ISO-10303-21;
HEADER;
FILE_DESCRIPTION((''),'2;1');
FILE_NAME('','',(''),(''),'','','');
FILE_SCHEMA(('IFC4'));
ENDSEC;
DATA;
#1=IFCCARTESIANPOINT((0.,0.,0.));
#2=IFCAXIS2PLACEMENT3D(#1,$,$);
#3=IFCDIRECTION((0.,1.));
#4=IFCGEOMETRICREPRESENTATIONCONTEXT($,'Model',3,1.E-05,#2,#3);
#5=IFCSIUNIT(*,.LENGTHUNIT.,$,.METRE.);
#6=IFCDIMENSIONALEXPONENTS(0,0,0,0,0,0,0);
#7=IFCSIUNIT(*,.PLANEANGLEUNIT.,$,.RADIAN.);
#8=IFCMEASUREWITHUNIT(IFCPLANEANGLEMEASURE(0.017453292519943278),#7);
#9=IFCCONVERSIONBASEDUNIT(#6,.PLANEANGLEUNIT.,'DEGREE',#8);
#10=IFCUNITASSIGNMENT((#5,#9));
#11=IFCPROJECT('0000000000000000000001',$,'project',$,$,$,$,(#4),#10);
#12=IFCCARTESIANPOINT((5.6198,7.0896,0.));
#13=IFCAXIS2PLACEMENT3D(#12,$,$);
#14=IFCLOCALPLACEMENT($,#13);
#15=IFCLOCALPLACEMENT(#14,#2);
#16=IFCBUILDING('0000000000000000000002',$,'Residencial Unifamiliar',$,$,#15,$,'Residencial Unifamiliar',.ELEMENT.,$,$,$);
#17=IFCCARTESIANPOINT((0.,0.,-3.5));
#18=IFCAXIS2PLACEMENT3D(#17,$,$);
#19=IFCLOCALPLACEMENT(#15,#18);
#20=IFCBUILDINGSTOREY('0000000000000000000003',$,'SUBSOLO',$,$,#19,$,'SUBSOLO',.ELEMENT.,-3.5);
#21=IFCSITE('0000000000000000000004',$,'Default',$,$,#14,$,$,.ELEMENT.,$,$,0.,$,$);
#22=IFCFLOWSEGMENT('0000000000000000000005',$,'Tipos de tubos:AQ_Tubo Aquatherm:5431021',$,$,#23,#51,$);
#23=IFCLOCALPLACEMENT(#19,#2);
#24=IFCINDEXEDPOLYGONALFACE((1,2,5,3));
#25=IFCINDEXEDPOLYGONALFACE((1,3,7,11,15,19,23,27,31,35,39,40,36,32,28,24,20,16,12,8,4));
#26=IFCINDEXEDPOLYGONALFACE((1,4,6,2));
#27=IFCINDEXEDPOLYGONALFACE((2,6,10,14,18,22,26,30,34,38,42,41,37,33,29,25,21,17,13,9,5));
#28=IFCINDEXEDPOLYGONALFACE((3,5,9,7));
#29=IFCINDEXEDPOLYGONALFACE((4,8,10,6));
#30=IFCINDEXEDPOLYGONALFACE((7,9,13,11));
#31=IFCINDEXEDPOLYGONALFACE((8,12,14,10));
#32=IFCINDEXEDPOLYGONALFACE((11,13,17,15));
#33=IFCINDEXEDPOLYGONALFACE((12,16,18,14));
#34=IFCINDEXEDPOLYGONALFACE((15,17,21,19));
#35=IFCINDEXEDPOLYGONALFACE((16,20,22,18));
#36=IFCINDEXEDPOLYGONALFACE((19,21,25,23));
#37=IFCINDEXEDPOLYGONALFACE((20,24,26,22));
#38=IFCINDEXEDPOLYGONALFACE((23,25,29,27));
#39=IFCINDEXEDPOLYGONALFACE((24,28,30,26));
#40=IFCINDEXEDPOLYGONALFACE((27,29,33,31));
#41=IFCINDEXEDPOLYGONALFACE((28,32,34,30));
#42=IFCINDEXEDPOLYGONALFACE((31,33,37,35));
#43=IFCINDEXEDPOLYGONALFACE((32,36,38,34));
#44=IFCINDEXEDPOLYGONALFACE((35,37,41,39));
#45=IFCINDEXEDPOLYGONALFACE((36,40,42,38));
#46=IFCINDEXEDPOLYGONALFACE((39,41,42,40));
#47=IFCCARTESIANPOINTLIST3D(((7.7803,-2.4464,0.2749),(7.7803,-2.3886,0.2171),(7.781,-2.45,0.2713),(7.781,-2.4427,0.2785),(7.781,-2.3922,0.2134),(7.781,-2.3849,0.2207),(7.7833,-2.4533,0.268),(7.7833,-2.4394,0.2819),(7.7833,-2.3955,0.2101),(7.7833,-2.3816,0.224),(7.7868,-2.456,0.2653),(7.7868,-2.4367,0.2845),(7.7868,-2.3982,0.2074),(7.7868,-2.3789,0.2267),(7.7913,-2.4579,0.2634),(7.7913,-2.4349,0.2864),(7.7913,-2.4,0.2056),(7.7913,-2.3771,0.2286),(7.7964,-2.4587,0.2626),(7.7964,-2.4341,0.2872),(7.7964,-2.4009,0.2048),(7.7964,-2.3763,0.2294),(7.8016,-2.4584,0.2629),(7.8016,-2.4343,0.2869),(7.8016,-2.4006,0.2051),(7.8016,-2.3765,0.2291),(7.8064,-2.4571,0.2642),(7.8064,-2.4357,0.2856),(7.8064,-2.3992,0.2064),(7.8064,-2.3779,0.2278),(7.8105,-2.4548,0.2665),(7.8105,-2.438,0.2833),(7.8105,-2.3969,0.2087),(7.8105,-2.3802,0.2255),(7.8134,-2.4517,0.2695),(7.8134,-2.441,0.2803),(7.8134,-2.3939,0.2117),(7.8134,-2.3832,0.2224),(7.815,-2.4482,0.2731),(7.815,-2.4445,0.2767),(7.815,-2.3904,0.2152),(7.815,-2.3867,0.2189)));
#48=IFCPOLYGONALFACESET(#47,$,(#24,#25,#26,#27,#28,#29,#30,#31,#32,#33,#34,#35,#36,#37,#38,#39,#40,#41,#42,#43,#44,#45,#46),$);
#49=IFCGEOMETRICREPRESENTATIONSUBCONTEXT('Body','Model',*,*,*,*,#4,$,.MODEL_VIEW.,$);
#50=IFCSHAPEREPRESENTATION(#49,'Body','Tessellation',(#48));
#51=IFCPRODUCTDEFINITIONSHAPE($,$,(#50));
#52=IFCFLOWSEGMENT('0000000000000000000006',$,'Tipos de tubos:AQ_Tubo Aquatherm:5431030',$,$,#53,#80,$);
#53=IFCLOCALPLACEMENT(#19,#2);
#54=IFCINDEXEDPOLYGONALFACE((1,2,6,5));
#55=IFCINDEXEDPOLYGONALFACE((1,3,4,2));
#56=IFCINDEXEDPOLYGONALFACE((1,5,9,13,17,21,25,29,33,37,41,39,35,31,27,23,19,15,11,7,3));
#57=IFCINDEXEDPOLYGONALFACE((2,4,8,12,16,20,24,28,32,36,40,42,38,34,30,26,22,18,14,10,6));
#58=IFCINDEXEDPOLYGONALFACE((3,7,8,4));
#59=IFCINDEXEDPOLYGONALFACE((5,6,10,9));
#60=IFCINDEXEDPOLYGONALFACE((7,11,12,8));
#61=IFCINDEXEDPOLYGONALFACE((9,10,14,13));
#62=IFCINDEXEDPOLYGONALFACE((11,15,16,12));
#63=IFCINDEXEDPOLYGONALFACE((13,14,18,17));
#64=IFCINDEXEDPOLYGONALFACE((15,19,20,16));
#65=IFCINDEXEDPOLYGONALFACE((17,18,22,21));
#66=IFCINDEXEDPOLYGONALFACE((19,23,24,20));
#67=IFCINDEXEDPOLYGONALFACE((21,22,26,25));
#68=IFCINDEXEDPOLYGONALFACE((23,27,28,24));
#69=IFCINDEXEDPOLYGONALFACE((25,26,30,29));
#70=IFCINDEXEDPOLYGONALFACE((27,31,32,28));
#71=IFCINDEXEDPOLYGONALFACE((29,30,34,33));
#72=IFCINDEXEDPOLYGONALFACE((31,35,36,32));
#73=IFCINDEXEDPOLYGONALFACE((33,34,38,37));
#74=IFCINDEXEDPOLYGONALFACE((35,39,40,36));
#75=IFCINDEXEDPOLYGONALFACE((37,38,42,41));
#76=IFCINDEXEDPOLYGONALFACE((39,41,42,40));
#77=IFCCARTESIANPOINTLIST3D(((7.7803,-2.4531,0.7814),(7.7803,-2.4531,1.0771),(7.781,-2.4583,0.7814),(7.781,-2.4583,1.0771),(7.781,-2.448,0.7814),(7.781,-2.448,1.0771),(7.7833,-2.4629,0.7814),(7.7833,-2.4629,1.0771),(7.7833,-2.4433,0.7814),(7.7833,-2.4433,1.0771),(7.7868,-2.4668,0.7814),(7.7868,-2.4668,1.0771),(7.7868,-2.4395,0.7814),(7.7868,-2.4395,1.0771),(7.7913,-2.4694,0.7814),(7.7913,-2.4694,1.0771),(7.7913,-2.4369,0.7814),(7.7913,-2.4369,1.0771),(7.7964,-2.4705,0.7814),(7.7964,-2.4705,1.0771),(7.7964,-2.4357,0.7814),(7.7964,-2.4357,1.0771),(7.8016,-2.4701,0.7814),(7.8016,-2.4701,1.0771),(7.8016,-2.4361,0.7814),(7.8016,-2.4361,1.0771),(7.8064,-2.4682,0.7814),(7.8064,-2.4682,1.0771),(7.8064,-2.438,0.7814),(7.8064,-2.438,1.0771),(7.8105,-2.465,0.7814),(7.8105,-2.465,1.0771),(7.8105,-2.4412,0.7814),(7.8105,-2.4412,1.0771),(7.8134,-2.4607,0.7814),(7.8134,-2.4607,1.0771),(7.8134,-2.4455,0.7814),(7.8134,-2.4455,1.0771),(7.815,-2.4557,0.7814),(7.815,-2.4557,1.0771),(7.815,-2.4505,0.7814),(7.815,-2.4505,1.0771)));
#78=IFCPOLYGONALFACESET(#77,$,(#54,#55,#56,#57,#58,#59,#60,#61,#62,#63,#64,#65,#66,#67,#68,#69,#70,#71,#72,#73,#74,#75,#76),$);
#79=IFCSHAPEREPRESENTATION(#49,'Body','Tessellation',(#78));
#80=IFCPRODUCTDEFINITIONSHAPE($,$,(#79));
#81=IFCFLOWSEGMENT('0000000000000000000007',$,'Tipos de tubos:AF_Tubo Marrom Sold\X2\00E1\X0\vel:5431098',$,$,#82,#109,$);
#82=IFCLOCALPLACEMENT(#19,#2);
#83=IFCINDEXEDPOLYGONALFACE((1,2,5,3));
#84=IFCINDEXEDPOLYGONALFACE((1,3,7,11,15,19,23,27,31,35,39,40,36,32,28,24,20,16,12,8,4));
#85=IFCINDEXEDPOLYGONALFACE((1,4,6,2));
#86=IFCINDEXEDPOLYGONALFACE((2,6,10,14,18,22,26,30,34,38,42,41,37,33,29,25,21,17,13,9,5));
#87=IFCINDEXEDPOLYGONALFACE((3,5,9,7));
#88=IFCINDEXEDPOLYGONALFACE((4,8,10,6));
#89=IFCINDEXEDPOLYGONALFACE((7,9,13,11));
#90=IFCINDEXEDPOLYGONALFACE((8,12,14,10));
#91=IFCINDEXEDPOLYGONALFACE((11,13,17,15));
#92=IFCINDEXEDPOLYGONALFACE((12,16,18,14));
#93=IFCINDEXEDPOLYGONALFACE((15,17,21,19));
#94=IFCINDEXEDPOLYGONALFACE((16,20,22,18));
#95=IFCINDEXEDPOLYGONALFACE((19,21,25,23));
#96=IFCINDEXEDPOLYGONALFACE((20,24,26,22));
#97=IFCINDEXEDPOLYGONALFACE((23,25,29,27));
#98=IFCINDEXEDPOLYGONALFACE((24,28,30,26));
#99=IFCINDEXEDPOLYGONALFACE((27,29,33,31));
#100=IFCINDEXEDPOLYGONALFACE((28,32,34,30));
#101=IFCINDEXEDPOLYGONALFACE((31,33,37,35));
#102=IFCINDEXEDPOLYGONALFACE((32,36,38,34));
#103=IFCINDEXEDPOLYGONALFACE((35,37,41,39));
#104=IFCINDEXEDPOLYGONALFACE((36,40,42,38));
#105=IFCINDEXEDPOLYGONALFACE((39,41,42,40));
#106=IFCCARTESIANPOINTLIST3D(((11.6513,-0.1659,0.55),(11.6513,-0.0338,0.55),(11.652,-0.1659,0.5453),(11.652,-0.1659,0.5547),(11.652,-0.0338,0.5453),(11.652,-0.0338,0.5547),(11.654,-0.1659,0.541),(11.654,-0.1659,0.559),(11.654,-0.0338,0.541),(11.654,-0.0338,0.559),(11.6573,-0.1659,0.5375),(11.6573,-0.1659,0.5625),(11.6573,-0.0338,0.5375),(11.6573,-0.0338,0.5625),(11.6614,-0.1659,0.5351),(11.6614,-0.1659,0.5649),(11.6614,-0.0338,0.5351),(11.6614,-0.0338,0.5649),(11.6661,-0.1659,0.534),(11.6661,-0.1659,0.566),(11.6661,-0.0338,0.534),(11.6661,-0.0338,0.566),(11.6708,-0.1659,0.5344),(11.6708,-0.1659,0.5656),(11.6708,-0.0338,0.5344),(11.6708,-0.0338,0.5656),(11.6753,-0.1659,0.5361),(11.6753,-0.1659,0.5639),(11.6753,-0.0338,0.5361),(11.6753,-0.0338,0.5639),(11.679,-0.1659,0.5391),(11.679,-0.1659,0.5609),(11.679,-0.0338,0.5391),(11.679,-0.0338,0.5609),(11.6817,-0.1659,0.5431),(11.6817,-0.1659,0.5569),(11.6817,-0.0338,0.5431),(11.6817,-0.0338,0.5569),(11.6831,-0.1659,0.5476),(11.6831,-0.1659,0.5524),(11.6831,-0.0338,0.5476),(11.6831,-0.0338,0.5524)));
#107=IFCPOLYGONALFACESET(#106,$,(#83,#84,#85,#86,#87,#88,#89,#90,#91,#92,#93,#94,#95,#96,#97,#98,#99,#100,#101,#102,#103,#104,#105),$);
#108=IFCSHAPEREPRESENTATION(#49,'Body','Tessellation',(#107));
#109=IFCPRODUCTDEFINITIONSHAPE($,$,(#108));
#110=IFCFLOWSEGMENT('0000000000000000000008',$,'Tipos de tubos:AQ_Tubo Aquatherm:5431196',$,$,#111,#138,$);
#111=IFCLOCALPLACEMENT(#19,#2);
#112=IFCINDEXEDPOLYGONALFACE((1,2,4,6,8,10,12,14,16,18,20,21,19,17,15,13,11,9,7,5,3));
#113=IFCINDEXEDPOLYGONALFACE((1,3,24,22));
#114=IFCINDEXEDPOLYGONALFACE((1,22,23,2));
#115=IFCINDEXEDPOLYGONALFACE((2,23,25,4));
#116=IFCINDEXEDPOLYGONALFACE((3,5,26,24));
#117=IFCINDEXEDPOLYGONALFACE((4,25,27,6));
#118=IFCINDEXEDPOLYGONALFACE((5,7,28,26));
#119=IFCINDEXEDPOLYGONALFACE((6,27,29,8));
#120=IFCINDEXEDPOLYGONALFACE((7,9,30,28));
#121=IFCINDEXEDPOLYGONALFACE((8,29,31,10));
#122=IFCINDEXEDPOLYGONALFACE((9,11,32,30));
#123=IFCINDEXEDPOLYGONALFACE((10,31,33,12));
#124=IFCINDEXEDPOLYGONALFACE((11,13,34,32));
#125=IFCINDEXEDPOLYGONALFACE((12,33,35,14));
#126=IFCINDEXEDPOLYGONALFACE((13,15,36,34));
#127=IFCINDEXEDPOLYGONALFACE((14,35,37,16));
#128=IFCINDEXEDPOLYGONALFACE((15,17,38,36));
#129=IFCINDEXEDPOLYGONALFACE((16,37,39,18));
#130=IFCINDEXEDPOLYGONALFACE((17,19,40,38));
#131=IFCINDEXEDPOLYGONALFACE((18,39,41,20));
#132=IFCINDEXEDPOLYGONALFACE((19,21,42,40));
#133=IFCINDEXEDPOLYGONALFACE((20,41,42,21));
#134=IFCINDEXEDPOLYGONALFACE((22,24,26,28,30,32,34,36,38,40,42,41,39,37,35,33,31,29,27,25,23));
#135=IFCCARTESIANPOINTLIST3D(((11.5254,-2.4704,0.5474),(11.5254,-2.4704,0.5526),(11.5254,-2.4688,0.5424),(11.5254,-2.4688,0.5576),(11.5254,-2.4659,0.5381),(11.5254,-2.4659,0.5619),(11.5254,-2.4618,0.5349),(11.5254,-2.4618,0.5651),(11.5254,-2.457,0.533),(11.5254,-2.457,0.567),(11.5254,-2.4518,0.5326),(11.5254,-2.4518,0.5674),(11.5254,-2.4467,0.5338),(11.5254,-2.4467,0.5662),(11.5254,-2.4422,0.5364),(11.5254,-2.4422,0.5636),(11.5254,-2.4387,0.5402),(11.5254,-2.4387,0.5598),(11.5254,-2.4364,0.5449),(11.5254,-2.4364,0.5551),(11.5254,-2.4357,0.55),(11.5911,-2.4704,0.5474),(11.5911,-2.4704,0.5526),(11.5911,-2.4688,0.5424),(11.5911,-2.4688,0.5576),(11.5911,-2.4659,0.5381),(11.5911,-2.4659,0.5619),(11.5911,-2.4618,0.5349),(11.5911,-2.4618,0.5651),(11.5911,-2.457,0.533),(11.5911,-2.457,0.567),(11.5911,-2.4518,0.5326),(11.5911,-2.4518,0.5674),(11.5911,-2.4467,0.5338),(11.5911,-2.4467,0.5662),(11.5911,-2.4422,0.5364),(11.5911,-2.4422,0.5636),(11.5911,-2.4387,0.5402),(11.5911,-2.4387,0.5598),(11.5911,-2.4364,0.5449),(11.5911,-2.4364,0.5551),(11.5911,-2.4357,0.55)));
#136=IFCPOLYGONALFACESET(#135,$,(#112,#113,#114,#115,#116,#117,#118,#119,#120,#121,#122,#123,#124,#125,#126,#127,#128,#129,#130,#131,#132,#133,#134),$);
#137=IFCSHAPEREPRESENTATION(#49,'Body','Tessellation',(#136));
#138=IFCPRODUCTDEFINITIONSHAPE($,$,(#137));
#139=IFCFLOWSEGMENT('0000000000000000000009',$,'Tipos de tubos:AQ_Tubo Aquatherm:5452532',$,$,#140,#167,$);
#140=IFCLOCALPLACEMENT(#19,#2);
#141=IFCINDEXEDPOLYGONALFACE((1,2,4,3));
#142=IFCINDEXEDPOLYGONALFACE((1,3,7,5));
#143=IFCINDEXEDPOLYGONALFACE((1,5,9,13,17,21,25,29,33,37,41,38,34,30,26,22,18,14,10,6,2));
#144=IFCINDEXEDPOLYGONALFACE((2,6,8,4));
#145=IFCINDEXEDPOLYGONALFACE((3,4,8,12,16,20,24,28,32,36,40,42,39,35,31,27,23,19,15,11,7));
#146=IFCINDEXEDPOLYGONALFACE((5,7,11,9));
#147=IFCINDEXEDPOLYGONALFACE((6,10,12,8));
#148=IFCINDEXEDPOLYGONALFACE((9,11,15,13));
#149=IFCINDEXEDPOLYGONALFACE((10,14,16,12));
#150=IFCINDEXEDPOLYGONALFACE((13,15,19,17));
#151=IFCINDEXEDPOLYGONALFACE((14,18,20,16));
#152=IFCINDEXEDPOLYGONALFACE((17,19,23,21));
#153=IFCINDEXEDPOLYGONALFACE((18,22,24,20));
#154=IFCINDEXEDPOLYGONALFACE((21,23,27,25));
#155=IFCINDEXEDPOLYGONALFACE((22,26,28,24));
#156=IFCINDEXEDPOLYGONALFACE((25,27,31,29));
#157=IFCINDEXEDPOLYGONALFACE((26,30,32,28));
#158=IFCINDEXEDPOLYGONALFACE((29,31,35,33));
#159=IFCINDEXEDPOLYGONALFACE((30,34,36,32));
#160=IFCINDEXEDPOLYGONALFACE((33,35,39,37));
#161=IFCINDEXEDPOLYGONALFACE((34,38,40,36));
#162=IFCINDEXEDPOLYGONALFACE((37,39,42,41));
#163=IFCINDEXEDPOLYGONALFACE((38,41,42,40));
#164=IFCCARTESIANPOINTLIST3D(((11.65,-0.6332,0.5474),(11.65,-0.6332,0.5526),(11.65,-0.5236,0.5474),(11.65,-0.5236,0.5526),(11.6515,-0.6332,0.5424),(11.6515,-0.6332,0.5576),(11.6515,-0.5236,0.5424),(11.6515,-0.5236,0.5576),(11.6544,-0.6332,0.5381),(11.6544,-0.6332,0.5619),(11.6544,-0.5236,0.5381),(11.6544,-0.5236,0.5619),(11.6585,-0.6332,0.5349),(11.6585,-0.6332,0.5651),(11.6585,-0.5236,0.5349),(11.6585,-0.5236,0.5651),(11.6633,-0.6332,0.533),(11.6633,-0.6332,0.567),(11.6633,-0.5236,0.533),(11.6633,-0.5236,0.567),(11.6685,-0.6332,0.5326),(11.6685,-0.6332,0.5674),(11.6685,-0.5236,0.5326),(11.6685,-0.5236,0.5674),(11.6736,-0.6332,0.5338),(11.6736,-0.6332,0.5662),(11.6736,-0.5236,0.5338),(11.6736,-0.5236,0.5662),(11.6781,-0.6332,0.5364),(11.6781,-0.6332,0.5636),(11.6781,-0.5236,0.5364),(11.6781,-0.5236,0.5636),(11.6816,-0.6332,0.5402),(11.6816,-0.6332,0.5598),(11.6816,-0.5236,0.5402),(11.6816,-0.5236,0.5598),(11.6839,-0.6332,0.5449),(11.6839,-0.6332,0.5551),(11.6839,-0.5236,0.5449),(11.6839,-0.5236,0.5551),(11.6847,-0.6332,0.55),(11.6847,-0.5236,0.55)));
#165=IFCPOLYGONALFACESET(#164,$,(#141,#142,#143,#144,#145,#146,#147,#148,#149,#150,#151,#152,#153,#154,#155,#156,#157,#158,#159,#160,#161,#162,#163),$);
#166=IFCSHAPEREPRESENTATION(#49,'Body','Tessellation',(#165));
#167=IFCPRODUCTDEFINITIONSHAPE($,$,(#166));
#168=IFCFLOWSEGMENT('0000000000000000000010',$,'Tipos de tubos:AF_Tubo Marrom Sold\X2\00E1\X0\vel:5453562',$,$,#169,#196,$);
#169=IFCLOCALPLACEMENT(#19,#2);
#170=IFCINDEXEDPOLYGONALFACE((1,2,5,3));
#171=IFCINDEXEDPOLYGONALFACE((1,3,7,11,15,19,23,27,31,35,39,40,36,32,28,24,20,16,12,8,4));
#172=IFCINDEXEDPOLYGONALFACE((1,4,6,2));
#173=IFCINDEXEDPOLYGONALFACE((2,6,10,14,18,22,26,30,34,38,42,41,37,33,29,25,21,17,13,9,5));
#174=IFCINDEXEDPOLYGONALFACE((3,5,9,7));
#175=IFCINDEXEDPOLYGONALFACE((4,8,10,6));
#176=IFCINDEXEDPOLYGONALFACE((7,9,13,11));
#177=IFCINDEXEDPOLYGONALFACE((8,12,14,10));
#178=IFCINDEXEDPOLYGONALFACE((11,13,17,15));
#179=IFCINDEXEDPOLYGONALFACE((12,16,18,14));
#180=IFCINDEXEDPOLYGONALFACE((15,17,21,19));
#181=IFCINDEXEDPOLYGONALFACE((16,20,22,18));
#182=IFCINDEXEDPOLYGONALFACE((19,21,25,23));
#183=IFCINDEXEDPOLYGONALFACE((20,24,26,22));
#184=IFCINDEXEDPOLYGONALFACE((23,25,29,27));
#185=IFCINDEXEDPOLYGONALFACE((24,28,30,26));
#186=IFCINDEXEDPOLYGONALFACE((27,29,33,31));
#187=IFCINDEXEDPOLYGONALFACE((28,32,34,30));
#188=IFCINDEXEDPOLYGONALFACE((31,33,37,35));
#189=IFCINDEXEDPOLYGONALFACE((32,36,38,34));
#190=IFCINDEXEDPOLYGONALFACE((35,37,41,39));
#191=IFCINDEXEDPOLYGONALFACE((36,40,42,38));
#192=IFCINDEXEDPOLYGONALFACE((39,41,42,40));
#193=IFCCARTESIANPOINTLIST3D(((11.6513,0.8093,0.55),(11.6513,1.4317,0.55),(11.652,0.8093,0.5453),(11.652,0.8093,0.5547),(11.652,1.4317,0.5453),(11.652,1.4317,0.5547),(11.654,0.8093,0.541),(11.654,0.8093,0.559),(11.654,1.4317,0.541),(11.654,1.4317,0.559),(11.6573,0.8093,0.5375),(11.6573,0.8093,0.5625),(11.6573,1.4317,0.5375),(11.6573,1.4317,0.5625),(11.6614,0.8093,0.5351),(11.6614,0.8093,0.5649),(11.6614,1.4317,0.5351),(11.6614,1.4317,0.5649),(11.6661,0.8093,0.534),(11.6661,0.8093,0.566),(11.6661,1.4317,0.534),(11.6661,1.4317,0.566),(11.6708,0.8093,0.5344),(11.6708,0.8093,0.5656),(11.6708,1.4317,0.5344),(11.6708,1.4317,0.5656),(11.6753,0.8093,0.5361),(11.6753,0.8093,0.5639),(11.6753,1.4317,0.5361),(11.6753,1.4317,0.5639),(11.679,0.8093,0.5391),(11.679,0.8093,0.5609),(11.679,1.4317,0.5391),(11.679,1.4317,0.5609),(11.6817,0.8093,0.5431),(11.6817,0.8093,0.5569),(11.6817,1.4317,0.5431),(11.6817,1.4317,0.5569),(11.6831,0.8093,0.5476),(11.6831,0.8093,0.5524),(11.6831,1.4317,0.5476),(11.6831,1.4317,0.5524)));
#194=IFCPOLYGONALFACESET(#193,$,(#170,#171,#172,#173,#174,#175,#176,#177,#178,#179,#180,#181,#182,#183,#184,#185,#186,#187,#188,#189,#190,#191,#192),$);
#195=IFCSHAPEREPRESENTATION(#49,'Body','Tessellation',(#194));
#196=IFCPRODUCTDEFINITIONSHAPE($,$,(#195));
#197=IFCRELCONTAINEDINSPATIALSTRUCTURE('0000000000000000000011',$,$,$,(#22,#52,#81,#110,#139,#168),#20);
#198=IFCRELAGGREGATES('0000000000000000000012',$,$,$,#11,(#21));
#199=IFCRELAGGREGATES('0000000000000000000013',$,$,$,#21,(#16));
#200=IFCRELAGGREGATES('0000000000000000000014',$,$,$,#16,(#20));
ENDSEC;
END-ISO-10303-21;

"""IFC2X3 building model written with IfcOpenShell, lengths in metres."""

from ifc_helpers import new_model, entity, si_unit, converted_unit, direction, frame, frame_2d, origin, origin_2d_with_axis, place, context, subcontext, project, spatial, circle, extrude, element, save


model = new_model("IFC2X3")

# Units and contexts
model_context = context("Model", 3, precision=1e-05, world=origin(), true_north=direction((0.0, 1.0)))
body_context = subcontext(model_context, "Body", "Model", "MODEL_VIEW")
ifc_project = project(units=[si_unit("LENGTHUNIT", "METRE"), converted_unit("PLANEANGLEUNIT", "DEGREE", entity("IfcPlaneAngleMeasure", 0.017453292519943278), si_unit("PLANEANGLEUNIT", "RADIAN"), dimensions=[0, 0, 0, 0, 0, 0, 0])], contexts=[model_context])

# Site, building, storey
site_placement = place(None, frame((5.6198, 7.0896, 0.0)))
site = spatial("IfcSite", under=ifc_project, at=site_placement, Name="Default", CompositionType="ELEMENT", RefElevation=0.0)
building_placement = place(site_placement, origin())
building = spatial("IfcBuilding", under=site, at=building_placement, Name="Residencial Unifamiliar", LongName="Residencial Unifamiliar", CompositionType="ELEMENT")
storey_placement = place(building_placement, frame((0.0, 0.0, -3.5)))
storey = spatial("IfcBuildingStorey", under=building, at=storey_placement, Name="SUBSOLO", LongName="SUBSOLO", CompositionType="ELEMENT", Elevation=-3.5)

# Flow segments
flow_segment_1_placement = place(storey_placement, origin())
element("IfcFlowSegment", 1, at=flow_segment_1_placement, inside=storey, Name="Tipos de tubos:AQ_Tubo Aquatherm:5431021", context=body_context, shape_type="SweptSolid", body=[
    extrude(circle(Radius=0.0175, at=origin_2d_with_axis()), frame((7.7977, -2.3886, 0.2171), z_axis=(0.000021, -0.707107, 0.707107), x_axis=(-1.0, -0.00003, 0.0)), (0.0, 0.0, 1.0), 0.0818),
])
flow_segment_2_placement = place(storey_placement, origin())
element("IfcFlowSegment", 2, at=flow_segment_2_placement, inside=storey, Name="Tipos de tubos:AQ_Tubo Aquatherm:5431030", context=body_context, shape_type="SweptSolid", body=[
    extrude(circle(Radius=0.0175, at=origin_2d_with_axis()), frame((7.7977, -2.4531, 0.7814), z_axis=(0.0, 0.0, 1.0), x_axis=(-1.0, 0.0, 0.0)), (0.0, 0.0, 1.0), 0.2957),
])
flow_segment_3_placement = place(storey_placement, origin())
element("IfcFlowSegment", 3, at=flow_segment_3_placement, inside=storey, Name="Tipos de tubos:AF_Tubo Marrom Soldável:5431098", context=body_context, shape_type="SweptSolid", body=[
    extrude(circle(Radius=0.016, at=origin_2d_with_axis()), frame((11.6673, -0.1659, 0.55), z_axis=(0.0, 1.0, 0.0), x_axis=(-1.0, 0.0, 0.0)), (0.0, 0.0, 1.0), 0.1321),
])
flow_segment_4_placement = place(storey_placement, origin())
element("IfcFlowSegment", 4, at=flow_segment_4_placement, inside=storey, Name="Tipos de tubos:AQ_Tubo Aquatherm:5431196", context=body_context, shape_type="SweptSolid", body=[
    extrude(circle(Radius=0.0175, at=frame_2d((0.0, 0.0), x_axis=(1.0, 0.0))), frame((11.5254, -2.4531, 0.55), z_axis=(1.0, 0.0, 0.0), x_axis=(0.0, 1.0, 0.0)), (0.0, 0.0, 1.0), 0.0657),
])
flow_segment_5_placement = place(storey_placement, origin())
element("IfcFlowSegment", 5, at=flow_segment_5_placement, inside=storey, Name="Tipos de tubos:AQ_Tubo Aquatherm:5452532", context=body_context, shape_type="SweptSolid", body=[
    extrude(circle(Radius=0.0175, at=origin_2d_with_axis()), frame((11.6672, -0.6332, 0.55), z_axis=(0.0, 1.0, 0.0), x_axis=(1.0, 0.0, 0.0)), (0.0, 0.0, 1.0), 0.1095),
])
flow_segment_6_placement = place(storey_placement, origin())
element("IfcFlowSegment", 6, at=flow_segment_6_placement, inside=storey, Name="Tipos de tubos:AF_Tubo Marrom Soldável:5453562", context=body_context, shape_type="SweptSolid", body=[
    extrude(circle(Radius=0.016, at=origin_2d_with_axis()), frame((11.6673, 0.8093, 0.55), z_axis=(0.0, 1.0, 0.0), x_axis=(-1.0, 0.0, 0.0)), (0.0, 0.0, 1.0), 0.6224),
])

save(model, "model.ifc")
